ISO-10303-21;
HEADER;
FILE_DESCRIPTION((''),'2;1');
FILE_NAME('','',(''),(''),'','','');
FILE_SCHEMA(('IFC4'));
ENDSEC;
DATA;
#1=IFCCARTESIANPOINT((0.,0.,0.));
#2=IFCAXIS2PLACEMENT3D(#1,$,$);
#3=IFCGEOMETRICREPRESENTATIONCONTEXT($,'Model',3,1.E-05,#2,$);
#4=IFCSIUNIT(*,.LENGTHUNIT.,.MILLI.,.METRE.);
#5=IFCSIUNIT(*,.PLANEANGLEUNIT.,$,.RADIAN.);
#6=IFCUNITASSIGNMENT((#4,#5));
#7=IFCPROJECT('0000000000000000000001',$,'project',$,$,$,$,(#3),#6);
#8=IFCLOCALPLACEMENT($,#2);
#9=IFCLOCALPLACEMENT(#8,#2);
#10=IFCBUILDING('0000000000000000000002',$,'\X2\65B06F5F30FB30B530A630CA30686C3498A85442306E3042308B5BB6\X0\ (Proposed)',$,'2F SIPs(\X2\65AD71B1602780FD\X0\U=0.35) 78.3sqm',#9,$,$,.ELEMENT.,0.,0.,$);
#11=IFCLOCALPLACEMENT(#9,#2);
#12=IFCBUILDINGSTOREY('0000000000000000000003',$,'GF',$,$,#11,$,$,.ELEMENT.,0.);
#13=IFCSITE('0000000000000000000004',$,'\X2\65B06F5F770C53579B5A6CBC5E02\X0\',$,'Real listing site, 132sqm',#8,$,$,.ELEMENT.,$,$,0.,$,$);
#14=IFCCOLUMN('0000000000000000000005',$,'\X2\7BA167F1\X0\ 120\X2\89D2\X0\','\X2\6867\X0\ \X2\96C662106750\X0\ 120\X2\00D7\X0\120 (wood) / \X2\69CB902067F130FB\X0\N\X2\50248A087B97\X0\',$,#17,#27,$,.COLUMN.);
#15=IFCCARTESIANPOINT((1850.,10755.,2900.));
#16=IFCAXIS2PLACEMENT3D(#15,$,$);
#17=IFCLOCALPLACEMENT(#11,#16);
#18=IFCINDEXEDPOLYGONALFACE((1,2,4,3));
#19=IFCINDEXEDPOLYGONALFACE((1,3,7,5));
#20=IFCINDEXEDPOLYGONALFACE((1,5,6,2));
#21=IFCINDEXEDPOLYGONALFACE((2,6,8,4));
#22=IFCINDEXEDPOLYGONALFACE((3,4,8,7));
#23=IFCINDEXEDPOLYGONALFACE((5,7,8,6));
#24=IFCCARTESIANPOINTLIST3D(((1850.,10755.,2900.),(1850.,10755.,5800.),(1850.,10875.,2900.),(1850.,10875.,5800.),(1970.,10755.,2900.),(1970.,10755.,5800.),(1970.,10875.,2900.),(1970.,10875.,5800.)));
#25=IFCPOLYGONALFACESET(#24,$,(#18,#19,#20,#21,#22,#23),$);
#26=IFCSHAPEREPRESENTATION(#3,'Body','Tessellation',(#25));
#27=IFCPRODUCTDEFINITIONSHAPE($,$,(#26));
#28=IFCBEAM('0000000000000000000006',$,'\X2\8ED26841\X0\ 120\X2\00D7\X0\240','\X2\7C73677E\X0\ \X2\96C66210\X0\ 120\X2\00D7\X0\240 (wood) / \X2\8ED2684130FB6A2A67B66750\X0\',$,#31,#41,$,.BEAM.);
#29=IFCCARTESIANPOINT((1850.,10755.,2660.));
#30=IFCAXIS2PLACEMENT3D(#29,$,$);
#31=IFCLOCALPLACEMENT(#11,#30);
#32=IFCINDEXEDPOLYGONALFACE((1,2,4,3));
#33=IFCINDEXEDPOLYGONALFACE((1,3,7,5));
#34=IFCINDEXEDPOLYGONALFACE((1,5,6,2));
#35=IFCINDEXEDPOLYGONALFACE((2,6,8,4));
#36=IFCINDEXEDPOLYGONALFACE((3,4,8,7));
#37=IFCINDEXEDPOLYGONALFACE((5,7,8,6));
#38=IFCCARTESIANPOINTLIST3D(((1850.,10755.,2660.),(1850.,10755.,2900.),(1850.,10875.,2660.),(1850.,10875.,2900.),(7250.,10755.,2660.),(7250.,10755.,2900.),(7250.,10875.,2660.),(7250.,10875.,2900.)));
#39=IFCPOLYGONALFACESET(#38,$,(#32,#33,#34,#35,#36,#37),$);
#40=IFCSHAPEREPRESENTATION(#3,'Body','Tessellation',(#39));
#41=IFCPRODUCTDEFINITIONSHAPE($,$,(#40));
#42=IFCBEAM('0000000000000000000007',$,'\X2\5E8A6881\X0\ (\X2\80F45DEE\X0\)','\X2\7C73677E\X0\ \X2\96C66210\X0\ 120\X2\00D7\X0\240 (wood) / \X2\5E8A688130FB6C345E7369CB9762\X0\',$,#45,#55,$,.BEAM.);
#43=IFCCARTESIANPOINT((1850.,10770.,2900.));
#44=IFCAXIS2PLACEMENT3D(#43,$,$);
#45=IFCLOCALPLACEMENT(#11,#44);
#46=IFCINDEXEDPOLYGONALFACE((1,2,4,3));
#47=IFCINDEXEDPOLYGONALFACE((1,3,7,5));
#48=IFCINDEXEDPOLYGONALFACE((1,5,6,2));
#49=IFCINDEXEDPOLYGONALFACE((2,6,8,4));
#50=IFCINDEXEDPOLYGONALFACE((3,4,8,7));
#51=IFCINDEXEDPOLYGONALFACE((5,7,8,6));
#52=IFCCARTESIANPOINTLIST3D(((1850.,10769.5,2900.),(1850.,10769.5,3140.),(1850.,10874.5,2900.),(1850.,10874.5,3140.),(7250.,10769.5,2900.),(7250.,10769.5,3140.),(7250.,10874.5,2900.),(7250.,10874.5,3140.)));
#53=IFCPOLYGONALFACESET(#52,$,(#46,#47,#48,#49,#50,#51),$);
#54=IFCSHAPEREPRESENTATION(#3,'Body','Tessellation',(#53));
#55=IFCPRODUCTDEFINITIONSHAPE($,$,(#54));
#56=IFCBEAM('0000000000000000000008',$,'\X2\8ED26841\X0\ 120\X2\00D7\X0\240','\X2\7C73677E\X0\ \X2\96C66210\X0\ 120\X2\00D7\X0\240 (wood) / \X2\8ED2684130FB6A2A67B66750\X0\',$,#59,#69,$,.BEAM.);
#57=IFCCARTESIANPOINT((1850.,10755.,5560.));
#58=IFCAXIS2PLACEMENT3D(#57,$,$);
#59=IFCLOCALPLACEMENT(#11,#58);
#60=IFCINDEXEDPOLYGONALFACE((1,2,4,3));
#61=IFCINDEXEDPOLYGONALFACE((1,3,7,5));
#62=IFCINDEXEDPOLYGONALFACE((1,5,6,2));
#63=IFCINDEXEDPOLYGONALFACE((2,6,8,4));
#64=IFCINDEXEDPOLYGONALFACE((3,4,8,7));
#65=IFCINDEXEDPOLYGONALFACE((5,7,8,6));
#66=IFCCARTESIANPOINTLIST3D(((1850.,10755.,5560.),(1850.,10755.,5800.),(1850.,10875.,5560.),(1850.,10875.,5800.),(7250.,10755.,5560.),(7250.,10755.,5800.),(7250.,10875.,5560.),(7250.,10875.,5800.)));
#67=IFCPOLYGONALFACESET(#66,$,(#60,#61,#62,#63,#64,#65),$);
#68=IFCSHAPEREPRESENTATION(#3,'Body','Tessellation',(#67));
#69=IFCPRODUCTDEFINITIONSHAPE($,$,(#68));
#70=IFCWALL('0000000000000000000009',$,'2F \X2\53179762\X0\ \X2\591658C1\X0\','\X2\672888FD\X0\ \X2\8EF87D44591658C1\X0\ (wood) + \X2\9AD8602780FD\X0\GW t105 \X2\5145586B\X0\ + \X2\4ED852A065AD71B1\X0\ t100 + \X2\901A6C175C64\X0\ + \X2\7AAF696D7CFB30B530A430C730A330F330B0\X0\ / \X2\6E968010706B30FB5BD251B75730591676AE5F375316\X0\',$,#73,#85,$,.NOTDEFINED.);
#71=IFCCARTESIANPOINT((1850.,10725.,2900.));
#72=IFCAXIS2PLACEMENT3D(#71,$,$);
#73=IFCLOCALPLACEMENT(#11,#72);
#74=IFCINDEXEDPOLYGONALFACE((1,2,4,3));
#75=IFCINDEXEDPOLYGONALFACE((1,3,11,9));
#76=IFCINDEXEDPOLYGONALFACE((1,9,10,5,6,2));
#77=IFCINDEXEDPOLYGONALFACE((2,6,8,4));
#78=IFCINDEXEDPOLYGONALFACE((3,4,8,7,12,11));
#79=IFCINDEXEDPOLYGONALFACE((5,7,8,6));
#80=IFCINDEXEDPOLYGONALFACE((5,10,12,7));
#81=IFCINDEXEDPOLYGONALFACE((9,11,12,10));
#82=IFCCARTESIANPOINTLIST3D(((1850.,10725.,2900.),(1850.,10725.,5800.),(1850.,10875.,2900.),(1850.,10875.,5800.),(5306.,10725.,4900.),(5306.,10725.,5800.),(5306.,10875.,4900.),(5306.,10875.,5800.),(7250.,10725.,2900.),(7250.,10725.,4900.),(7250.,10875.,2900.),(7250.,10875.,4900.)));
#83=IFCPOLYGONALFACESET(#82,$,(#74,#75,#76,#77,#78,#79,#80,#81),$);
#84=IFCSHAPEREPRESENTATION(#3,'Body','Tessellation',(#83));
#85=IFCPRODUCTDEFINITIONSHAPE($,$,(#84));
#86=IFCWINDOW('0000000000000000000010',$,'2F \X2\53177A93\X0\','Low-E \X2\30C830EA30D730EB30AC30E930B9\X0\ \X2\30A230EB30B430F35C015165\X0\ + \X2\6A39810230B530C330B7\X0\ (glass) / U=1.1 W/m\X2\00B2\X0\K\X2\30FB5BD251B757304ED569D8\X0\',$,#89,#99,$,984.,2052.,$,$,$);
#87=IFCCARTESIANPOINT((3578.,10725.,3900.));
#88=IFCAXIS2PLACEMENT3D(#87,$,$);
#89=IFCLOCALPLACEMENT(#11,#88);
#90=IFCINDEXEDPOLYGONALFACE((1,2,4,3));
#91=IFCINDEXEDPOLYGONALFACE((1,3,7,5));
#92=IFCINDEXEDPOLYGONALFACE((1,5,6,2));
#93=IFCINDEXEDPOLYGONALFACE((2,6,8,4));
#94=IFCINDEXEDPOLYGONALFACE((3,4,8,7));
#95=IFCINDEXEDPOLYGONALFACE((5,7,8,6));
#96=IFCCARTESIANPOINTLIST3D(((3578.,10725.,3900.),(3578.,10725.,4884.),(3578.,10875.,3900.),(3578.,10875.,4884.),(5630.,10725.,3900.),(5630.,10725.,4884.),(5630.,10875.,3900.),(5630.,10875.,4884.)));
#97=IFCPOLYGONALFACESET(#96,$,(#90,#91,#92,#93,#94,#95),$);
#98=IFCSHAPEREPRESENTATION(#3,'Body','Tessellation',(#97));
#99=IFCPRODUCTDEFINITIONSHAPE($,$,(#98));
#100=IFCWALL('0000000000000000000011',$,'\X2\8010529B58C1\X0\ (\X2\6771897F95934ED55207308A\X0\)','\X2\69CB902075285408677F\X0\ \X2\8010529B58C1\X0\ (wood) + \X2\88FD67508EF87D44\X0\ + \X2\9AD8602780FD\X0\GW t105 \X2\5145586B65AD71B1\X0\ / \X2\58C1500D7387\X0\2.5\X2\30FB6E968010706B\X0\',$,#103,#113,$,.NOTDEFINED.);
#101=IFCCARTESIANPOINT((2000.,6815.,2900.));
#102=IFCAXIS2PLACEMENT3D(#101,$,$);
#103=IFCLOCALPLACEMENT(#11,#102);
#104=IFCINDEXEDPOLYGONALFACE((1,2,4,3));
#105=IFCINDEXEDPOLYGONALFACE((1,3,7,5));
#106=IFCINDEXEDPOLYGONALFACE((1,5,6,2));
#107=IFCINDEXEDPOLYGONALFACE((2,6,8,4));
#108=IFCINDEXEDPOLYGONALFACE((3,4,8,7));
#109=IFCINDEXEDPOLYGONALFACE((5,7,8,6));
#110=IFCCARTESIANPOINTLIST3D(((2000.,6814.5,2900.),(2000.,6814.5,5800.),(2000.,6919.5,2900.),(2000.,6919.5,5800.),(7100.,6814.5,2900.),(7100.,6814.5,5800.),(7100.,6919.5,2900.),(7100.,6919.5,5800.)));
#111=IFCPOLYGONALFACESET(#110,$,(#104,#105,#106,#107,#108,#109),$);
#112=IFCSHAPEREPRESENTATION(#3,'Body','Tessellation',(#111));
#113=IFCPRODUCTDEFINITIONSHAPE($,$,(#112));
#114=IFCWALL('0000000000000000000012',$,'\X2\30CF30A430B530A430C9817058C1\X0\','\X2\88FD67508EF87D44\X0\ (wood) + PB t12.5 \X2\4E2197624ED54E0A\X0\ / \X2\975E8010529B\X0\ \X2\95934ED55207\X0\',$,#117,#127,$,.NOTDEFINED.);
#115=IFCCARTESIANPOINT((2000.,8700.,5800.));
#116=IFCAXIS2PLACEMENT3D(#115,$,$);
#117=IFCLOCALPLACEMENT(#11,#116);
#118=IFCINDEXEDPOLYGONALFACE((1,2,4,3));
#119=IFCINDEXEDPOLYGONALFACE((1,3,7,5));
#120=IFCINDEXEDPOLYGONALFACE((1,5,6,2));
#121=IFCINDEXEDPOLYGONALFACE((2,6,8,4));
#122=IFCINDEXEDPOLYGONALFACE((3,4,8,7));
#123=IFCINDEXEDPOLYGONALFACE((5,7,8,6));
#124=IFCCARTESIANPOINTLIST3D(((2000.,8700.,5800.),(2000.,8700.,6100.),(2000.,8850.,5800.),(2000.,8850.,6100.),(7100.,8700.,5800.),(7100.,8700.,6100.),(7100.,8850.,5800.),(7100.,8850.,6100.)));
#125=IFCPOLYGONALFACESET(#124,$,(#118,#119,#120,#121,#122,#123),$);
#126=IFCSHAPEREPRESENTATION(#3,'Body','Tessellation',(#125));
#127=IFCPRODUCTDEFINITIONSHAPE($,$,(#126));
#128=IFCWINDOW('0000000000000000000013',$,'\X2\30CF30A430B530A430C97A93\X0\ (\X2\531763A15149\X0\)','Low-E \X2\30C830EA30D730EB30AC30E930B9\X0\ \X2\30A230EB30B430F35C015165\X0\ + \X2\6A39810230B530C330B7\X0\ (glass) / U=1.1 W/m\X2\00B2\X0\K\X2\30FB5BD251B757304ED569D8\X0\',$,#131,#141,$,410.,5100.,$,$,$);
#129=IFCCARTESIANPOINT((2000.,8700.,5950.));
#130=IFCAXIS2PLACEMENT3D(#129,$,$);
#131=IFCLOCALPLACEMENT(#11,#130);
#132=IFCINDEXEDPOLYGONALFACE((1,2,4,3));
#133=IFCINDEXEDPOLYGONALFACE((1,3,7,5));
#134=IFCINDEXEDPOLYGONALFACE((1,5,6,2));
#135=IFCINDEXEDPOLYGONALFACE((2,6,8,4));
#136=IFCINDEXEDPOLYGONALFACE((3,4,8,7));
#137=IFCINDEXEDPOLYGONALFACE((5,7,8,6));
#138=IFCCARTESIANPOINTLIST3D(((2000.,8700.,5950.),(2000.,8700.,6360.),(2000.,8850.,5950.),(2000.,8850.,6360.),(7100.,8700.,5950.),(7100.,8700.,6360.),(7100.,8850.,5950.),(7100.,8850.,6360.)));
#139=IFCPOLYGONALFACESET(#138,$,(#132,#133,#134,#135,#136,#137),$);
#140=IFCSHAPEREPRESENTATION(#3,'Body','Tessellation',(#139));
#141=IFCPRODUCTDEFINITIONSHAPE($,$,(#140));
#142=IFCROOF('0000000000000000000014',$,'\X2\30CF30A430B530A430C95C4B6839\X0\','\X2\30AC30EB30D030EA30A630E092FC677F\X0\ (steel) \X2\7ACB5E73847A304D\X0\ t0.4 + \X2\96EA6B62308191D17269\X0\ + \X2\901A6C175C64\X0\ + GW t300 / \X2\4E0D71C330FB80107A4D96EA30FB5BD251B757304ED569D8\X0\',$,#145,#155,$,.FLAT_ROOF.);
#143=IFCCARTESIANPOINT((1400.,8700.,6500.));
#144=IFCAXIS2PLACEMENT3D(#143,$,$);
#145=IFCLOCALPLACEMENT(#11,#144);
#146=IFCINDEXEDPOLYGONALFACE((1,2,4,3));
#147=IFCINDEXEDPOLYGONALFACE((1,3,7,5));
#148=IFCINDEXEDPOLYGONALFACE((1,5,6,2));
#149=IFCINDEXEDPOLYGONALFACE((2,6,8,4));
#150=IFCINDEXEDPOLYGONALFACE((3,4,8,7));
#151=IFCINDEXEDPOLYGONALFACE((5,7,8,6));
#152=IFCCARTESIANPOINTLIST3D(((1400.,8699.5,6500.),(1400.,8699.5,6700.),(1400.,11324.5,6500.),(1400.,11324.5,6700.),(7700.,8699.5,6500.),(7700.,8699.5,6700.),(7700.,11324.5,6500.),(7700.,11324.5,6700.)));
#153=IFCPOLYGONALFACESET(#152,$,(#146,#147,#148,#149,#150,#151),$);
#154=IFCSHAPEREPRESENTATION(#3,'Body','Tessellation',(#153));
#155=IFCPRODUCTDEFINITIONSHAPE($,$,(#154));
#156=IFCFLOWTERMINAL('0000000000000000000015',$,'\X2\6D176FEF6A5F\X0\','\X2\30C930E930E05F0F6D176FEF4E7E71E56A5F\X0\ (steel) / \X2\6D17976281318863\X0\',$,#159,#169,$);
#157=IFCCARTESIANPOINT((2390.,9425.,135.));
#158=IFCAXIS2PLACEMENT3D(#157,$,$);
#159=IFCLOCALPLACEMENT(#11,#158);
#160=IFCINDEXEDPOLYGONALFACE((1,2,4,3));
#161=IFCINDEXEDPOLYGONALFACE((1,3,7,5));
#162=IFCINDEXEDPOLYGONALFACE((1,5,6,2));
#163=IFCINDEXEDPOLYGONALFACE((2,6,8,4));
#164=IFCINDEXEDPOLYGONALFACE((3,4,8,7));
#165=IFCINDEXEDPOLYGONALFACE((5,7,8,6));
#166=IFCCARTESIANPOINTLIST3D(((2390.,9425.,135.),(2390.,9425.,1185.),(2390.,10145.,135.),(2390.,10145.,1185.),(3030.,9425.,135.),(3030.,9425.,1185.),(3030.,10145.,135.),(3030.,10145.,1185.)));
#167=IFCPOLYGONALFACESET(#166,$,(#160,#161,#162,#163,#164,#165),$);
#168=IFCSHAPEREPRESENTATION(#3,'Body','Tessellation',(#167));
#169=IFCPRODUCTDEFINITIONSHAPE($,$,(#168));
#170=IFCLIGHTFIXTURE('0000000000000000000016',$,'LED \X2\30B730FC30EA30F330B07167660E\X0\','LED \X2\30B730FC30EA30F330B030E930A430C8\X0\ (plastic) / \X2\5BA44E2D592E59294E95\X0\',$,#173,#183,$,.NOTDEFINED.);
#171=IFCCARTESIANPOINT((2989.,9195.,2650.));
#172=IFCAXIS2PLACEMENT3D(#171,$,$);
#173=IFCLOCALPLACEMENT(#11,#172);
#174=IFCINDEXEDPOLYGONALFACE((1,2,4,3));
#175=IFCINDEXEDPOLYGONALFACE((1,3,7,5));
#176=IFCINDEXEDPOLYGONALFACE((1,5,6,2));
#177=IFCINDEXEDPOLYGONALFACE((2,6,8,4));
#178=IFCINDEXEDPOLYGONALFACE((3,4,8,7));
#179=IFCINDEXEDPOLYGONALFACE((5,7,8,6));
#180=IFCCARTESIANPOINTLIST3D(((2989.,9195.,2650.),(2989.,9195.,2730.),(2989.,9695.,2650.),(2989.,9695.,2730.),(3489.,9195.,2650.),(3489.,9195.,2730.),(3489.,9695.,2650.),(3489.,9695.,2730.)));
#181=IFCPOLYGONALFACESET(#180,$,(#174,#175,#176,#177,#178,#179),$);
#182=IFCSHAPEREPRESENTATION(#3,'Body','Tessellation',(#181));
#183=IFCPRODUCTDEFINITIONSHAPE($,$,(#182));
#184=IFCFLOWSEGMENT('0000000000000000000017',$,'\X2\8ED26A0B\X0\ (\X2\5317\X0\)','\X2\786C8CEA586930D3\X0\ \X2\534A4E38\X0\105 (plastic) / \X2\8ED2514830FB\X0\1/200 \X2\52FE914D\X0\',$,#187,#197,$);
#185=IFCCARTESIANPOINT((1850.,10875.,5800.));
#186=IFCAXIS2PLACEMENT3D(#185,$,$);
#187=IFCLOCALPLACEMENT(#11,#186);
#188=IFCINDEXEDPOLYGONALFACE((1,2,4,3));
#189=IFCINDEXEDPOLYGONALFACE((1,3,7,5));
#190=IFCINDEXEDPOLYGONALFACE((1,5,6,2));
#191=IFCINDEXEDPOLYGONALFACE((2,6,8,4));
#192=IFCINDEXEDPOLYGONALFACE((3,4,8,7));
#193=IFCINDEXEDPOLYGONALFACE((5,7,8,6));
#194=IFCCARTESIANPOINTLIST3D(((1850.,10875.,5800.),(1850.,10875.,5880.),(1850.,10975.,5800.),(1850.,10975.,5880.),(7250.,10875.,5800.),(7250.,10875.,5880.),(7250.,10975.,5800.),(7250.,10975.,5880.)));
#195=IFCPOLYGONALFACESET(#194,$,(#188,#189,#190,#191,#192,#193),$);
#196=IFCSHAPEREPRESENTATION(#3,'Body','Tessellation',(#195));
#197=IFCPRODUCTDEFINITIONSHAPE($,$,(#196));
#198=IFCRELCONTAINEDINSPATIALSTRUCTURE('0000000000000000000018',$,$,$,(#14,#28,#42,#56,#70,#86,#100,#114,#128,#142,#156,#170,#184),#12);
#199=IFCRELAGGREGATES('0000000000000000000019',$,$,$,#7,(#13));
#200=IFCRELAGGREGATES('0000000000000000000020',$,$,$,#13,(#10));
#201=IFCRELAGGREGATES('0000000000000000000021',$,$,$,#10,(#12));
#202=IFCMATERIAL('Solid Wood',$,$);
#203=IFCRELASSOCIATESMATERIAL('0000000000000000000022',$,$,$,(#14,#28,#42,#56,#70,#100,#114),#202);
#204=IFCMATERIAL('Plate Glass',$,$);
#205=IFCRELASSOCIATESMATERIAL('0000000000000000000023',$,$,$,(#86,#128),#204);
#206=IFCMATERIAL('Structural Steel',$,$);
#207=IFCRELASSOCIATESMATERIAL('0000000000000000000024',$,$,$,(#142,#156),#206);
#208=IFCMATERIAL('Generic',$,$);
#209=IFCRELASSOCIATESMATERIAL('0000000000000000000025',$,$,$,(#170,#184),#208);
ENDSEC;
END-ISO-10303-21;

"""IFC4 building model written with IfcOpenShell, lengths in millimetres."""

from ifc_helpers import new_model, si_unit, frame, frame_2d, origin, place, context, project, spatial, rectangle, extrude, material, element, fill, save


model = new_model("IFC4")

# Units and contexts
model_context = context("Model", 3, precision=1e-05, world=origin())
ifc_project = project(units=[si_unit("LENGTHUNIT", "METRE", prefix="MILLI"), si_unit("PLANEANGLEUNIT", "RADIAN")], contexts=[model_context])

# Site, building, storey
site_placement = place(None, origin())
site = spatial("IfcSite", under=ifc_project, at=site_placement, Name="新潟県南魚沼市", ObjectType="Real listing site, 132sqm", CompositionType="ELEMENT", RefElevation=0.0)
building_placement = place(site_placement, origin())
building = spatial("IfcBuilding", under=site, at=building_placement, Name="新潟・サウナと水風呂のある家 (Proposed)", ObjectType="2F SIPs(断熱性能U=0.35) 78.3sqm", CompositionType="ELEMENT", ElevationOfRefHeight=0.0, ElevationOfTerrain=0.0)
storey_placement = place(building_placement, origin())
storey = spatial("IfcBuildingStorey", under=building, at=storey_placement, Name="GF", CompositionType="ELEMENT", Elevation=0.0)

# Column
ifc_material_1 = material(Name="Solid Wood")
column_1_placement = place(storey_placement, frame((1850.0, 10755.0, 2900.0)))
element("IfcColumn", 1, at=column_1_placement, inside=storey, material=ifc_material_1, Name="管柱 120角", Description="桧 集成材 120×120 (wood) / 構造柱・N値計算", PredefinedType="COLUMN", context=model_context, shape_type="SweptSolid", body=[
    extrude(rectangle(XDim=120.0, YDim=120.0, at=frame_2d((60.0, 60.0))), frame((1850.0, 10755.0, 2900.0)), (0.0, 0.0, 1.0), 2900.0),
])

# Beams
beam_1_placement = place(storey_placement, frame((1850.0, 10755.0, 2660.0)))
element("IfcBeam", 2, at=beam_1_placement, inside=storey, material=ifc_material_1, Name="軒桁 120×240", Description="米松 集成 120×240 (wood) / 軒桁・横架材", PredefinedType="BEAM", context=model_context, shape_type="SweptSolid", body=[
    extrude(rectangle(XDim=5400.0, YDim=120.0, at=frame_2d((2700.0, 60.0))), frame((1850.0, 10755.0, 2660.0)), (0.0, 0.0, 1.0), 240.0),
])
beam_2_placement = place(storey_placement, frame((1850.0, 10770.0, 2900.0)))
element("IfcBeam", 3, at=beam_2_placement, inside=storey, material=ifc_material_1, Name="床梁 (胴差)", Description="米松 集成 120×240 (wood) / 床梁・水平構面", PredefinedType="BEAM", context=model_context, shape_type="SweptSolid", body=[
    extrude(rectangle(XDim=5400.0, YDim=105.0, at=frame_2d((2700.0, 52.0))), frame((1850.0, 10770.0, 2900.0)), (0.0, 0.0, 1.0), 240.0),
])
beam_3_placement = place(storey_placement, frame((1850.0, 10755.0, 5560.0)))
element("IfcBeam", 4, at=beam_3_placement, inside=storey, material=ifc_material_1, Name="軒桁 120×240", Description="米松 集成 120×240 (wood) / 軒桁・横架材", PredefinedType="BEAM", context=model_context, shape_type="SweptSolid", body=[
    extrude(rectangle(XDim=5400.0, YDim=120.0, at=frame_2d((2700.0, 60.0))), frame((1850.0, 10755.0, 5560.0)), (0.0, 0.0, 1.0), 240.0),
])

# Wall, opening, window
wall_1_placement = place(storey_placement, frame((1850.0, 10725.0, 2900.0)))
wall_1 = element("IfcWall", 5, at=wall_1_placement, inside=storey, material=ifc_material_1, Name="2F 北面 外壁", Description="木製 軸組外壁 (wood) + 高性能GW t105 充填 + 付加断熱 t100 + 通気層 + 窯業系サイディング / 準耐火・寒冷地外皮強化", PredefinedType="NOTDEFINED", context=model_context, shape_type="SweptSolid", body=[
    extrude(rectangle(XDim=5400.0, YDim=150.0, at=frame_2d((2700.0, 75.0))), frame((1850.0, 10725.0, 2900.0)), (0.0, 0.0, 1.0), 2900.0),
])
opening_1_placement = place(storey_placement, frame((3578.0, 10725.0, 3900.0)))
opening_1 = element("IfcOpeningElement", 6, at=opening_1_placement, cuts=wall_1, PredefinedType="NOTDEFINED", context=model_context, shape_type="SweptSolid", body=[
    extrude(rectangle(XDim=2052.0, YDim=150.0, at=frame_2d((1026.0, 75.0))), frame((3578.0, 10725.0, 3900.0)), (0.0, 0.0, 1.0), 984.0),
])
ifc_material_2 = material(Name="Plate Glass")
window_1_placement = place(storey_placement, frame((3578.0, 10725.0, 3900.0)))
window_1 = element("IfcWindow", 7, at=window_1_placement, inside=storey, material=ifc_material_2, Name="2F 北窓", Description="Low-E トリプルガラス アルゴン封入 + 樹脂サッシ (glass) / U=1.1 W/m²K・寒冷地仕様", OverallHeight=984.0, OverallWidth=2052.0, context=model_context, shape_type="SweptSolid", body=[
    extrude(rectangle(XDim=2052.0, YDim=150.0, at=frame_2d((1026.0, 75.0))), frame((3578.0, 10725.0, 3900.0)), (0.0, 0.0, 1.0), 984.0),
])
fill(opening_1, window_1)

# Wall
wall_2_placement = place(storey_placement, frame((2000.0, 6815.0, 2900.0)))
element("IfcWall", 8, at=wall_2_placement, inside=storey, material=ifc_material_1, Name="耐力壁 (東西間仕切り)", Description="構造用合板 耐力壁 (wood) + 製材軸組 + 高性能GW t105 充填断熱 / 壁倍率2.5・準耐火", PredefinedType="NOTDEFINED", context=model_context, shape_type="SweptSolid", body=[
    extrude(rectangle(XDim=5100.0, YDim=105.0, at=frame_2d((2550.0, 52.0))), frame((2000.0, 6815.0, 2900.0)), (0.0, 0.0, 1.0), 2900.0),
])

# Wall, opening, window
wall_3_placement = place(storey_placement, frame((2000.0, 8700.0, 5800.0)))
wall_3 = element("IfcWall", 9, at=wall_3_placement, inside=storey, material=ifc_material_1, Name="ハイサイド腰壁", Description="製材軸組 (wood) + PB t12.5 両面仕上 / 非耐力 間仕切", PredefinedType="NOTDEFINED", context=model_context, shape_type="SweptSolid", body=[
    extrude(rectangle(XDim=5100.0, YDim=150.0, at=frame_2d((2550.0, 75.0))), frame((2000.0, 8700.0, 5800.0)), (0.0, 0.0, 1.0), 700.0),
])
opening_2_placement = place(storey_placement, frame((2000.0, 8700.0, 5950.0)))
opening_2 = element("IfcOpeningElement", 10, at=opening_2_placement, cuts=wall_3, PredefinedType="NOTDEFINED", context=model_context, shape_type="SweptSolid", body=[
    extrude(rectangle(XDim=5100.0, YDim=150.0, at=frame_2d((2550.0, 75.0))), frame((2000.0, 8700.0, 5950.0)), (0.0, 0.0, 1.0), 410.0),
])
window_2_placement = place(storey_placement, frame((2000.0, 8700.0, 5950.0)))
window_2 = element("IfcWindow", 11, at=window_2_placement, inside=storey, material=ifc_material_2, Name="ハイサイド窓 (北採光)", Description="Low-E トリプルガラス アルゴン封入 + 樹脂サッシ (glass) / U=1.1 W/m²K・寒冷地仕様", OverallHeight=410.0, OverallWidth=5100.0, context=model_context, shape_type="SweptSolid", body=[
    extrude(rectangle(XDim=5100.0, YDim=150.0, at=frame_2d((2550.0, 75.0))), frame((2000.0, 8700.0, 5950.0)), (0.0, 0.0, 1.0), 410.0),
])
fill(opening_2, window_2)

# Roof
ifc_material_3 = material(Name="Structural Steel")
roof_placement = place(storey_placement, frame((1400.0, 8700.0, 6500.0)))
element("IfcRoof", 12, at=roof_placement, inside=storey, material=ifc_material_3, Name="ハイサイド屋根", Description="ガルバリウム鋼板 (steel) 立平葺き t0.4 + 雪止め金物 + 通気層 + GW t300 / 不燃・耐積雪・寒冷地仕様", PredefinedType="FLAT_ROOF", context=model_context, shape_type="SweptSolid", body=[
    extrude(rectangle(XDim=6300.0, YDim=2625.0, at=frame_2d((3150.0, 1312.0))), frame((1400.0, 8700.0, 6500.0)), (0.0, 0.0, 1.0), 200.0),
])

# Flow terminal
flow_terminal_placement = place(storey_placement, frame((2390.0, 9425.0, 135.0)))
element("IfcFlowTerminal", 13, at=flow_terminal_placement, inside=storey, material=ifc_material_3, Name="洗濯機", Description="ドラム式洗濯乾燥機 (steel) / 洗面脱衣", context=model_context, shape_type="SweptSolid", body=[
    extrude(rectangle(XDim=640.0, YDim=720.0, at=frame_2d((320.0, 360.0))), frame((2390.0, 9425.0, 135.0)), (0.0, 0.0, 1.0), 1050.0),
])

# Light fixture
ifc_material_4 = material(Name="Generic")
light_fixture_placement = place(storey_placement, frame((2989.0, 9195.0, 2650.0)))
element("IfcLightFixture", 14, at=light_fixture_placement, inside=storey, material=ifc_material_4, Name="LED シーリング照明", Description="LED シーリングライト (plastic) / 室中央天井", PredefinedType="NOTDEFINED", context=model_context, shape_type="SweptSolid", body=[
    extrude(rectangle(XDim=500.0, YDim=500.0, at=frame_2d((250.0, 250.0))), frame((2989.0, 9195.0, 2650.0)), (0.0, 0.0, 1.0), 80.0),
])

# Flow segment
flow_segment_placement = place(storey_placement, frame((1850.0, 10875.0, 5800.0)))
element("IfcFlowSegment", 15, at=flow_segment_placement, inside=storey, material=ifc_material_4, Name="軒樋 (北)", Description="硬質塩ビ 半丸105 (plastic) / 軒先・1/200 勾配", context=model_context, shape_type="SweptSolid", body=[
    extrude(rectangle(XDim=5400.0, YDim=100.0, at=frame_2d((2700.0, 50.0))), frame((1850.0, 10875.0, 5800.0)), (0.0, 0.0, 1.0), 80.0),
])

save(model, "model.ifc")
